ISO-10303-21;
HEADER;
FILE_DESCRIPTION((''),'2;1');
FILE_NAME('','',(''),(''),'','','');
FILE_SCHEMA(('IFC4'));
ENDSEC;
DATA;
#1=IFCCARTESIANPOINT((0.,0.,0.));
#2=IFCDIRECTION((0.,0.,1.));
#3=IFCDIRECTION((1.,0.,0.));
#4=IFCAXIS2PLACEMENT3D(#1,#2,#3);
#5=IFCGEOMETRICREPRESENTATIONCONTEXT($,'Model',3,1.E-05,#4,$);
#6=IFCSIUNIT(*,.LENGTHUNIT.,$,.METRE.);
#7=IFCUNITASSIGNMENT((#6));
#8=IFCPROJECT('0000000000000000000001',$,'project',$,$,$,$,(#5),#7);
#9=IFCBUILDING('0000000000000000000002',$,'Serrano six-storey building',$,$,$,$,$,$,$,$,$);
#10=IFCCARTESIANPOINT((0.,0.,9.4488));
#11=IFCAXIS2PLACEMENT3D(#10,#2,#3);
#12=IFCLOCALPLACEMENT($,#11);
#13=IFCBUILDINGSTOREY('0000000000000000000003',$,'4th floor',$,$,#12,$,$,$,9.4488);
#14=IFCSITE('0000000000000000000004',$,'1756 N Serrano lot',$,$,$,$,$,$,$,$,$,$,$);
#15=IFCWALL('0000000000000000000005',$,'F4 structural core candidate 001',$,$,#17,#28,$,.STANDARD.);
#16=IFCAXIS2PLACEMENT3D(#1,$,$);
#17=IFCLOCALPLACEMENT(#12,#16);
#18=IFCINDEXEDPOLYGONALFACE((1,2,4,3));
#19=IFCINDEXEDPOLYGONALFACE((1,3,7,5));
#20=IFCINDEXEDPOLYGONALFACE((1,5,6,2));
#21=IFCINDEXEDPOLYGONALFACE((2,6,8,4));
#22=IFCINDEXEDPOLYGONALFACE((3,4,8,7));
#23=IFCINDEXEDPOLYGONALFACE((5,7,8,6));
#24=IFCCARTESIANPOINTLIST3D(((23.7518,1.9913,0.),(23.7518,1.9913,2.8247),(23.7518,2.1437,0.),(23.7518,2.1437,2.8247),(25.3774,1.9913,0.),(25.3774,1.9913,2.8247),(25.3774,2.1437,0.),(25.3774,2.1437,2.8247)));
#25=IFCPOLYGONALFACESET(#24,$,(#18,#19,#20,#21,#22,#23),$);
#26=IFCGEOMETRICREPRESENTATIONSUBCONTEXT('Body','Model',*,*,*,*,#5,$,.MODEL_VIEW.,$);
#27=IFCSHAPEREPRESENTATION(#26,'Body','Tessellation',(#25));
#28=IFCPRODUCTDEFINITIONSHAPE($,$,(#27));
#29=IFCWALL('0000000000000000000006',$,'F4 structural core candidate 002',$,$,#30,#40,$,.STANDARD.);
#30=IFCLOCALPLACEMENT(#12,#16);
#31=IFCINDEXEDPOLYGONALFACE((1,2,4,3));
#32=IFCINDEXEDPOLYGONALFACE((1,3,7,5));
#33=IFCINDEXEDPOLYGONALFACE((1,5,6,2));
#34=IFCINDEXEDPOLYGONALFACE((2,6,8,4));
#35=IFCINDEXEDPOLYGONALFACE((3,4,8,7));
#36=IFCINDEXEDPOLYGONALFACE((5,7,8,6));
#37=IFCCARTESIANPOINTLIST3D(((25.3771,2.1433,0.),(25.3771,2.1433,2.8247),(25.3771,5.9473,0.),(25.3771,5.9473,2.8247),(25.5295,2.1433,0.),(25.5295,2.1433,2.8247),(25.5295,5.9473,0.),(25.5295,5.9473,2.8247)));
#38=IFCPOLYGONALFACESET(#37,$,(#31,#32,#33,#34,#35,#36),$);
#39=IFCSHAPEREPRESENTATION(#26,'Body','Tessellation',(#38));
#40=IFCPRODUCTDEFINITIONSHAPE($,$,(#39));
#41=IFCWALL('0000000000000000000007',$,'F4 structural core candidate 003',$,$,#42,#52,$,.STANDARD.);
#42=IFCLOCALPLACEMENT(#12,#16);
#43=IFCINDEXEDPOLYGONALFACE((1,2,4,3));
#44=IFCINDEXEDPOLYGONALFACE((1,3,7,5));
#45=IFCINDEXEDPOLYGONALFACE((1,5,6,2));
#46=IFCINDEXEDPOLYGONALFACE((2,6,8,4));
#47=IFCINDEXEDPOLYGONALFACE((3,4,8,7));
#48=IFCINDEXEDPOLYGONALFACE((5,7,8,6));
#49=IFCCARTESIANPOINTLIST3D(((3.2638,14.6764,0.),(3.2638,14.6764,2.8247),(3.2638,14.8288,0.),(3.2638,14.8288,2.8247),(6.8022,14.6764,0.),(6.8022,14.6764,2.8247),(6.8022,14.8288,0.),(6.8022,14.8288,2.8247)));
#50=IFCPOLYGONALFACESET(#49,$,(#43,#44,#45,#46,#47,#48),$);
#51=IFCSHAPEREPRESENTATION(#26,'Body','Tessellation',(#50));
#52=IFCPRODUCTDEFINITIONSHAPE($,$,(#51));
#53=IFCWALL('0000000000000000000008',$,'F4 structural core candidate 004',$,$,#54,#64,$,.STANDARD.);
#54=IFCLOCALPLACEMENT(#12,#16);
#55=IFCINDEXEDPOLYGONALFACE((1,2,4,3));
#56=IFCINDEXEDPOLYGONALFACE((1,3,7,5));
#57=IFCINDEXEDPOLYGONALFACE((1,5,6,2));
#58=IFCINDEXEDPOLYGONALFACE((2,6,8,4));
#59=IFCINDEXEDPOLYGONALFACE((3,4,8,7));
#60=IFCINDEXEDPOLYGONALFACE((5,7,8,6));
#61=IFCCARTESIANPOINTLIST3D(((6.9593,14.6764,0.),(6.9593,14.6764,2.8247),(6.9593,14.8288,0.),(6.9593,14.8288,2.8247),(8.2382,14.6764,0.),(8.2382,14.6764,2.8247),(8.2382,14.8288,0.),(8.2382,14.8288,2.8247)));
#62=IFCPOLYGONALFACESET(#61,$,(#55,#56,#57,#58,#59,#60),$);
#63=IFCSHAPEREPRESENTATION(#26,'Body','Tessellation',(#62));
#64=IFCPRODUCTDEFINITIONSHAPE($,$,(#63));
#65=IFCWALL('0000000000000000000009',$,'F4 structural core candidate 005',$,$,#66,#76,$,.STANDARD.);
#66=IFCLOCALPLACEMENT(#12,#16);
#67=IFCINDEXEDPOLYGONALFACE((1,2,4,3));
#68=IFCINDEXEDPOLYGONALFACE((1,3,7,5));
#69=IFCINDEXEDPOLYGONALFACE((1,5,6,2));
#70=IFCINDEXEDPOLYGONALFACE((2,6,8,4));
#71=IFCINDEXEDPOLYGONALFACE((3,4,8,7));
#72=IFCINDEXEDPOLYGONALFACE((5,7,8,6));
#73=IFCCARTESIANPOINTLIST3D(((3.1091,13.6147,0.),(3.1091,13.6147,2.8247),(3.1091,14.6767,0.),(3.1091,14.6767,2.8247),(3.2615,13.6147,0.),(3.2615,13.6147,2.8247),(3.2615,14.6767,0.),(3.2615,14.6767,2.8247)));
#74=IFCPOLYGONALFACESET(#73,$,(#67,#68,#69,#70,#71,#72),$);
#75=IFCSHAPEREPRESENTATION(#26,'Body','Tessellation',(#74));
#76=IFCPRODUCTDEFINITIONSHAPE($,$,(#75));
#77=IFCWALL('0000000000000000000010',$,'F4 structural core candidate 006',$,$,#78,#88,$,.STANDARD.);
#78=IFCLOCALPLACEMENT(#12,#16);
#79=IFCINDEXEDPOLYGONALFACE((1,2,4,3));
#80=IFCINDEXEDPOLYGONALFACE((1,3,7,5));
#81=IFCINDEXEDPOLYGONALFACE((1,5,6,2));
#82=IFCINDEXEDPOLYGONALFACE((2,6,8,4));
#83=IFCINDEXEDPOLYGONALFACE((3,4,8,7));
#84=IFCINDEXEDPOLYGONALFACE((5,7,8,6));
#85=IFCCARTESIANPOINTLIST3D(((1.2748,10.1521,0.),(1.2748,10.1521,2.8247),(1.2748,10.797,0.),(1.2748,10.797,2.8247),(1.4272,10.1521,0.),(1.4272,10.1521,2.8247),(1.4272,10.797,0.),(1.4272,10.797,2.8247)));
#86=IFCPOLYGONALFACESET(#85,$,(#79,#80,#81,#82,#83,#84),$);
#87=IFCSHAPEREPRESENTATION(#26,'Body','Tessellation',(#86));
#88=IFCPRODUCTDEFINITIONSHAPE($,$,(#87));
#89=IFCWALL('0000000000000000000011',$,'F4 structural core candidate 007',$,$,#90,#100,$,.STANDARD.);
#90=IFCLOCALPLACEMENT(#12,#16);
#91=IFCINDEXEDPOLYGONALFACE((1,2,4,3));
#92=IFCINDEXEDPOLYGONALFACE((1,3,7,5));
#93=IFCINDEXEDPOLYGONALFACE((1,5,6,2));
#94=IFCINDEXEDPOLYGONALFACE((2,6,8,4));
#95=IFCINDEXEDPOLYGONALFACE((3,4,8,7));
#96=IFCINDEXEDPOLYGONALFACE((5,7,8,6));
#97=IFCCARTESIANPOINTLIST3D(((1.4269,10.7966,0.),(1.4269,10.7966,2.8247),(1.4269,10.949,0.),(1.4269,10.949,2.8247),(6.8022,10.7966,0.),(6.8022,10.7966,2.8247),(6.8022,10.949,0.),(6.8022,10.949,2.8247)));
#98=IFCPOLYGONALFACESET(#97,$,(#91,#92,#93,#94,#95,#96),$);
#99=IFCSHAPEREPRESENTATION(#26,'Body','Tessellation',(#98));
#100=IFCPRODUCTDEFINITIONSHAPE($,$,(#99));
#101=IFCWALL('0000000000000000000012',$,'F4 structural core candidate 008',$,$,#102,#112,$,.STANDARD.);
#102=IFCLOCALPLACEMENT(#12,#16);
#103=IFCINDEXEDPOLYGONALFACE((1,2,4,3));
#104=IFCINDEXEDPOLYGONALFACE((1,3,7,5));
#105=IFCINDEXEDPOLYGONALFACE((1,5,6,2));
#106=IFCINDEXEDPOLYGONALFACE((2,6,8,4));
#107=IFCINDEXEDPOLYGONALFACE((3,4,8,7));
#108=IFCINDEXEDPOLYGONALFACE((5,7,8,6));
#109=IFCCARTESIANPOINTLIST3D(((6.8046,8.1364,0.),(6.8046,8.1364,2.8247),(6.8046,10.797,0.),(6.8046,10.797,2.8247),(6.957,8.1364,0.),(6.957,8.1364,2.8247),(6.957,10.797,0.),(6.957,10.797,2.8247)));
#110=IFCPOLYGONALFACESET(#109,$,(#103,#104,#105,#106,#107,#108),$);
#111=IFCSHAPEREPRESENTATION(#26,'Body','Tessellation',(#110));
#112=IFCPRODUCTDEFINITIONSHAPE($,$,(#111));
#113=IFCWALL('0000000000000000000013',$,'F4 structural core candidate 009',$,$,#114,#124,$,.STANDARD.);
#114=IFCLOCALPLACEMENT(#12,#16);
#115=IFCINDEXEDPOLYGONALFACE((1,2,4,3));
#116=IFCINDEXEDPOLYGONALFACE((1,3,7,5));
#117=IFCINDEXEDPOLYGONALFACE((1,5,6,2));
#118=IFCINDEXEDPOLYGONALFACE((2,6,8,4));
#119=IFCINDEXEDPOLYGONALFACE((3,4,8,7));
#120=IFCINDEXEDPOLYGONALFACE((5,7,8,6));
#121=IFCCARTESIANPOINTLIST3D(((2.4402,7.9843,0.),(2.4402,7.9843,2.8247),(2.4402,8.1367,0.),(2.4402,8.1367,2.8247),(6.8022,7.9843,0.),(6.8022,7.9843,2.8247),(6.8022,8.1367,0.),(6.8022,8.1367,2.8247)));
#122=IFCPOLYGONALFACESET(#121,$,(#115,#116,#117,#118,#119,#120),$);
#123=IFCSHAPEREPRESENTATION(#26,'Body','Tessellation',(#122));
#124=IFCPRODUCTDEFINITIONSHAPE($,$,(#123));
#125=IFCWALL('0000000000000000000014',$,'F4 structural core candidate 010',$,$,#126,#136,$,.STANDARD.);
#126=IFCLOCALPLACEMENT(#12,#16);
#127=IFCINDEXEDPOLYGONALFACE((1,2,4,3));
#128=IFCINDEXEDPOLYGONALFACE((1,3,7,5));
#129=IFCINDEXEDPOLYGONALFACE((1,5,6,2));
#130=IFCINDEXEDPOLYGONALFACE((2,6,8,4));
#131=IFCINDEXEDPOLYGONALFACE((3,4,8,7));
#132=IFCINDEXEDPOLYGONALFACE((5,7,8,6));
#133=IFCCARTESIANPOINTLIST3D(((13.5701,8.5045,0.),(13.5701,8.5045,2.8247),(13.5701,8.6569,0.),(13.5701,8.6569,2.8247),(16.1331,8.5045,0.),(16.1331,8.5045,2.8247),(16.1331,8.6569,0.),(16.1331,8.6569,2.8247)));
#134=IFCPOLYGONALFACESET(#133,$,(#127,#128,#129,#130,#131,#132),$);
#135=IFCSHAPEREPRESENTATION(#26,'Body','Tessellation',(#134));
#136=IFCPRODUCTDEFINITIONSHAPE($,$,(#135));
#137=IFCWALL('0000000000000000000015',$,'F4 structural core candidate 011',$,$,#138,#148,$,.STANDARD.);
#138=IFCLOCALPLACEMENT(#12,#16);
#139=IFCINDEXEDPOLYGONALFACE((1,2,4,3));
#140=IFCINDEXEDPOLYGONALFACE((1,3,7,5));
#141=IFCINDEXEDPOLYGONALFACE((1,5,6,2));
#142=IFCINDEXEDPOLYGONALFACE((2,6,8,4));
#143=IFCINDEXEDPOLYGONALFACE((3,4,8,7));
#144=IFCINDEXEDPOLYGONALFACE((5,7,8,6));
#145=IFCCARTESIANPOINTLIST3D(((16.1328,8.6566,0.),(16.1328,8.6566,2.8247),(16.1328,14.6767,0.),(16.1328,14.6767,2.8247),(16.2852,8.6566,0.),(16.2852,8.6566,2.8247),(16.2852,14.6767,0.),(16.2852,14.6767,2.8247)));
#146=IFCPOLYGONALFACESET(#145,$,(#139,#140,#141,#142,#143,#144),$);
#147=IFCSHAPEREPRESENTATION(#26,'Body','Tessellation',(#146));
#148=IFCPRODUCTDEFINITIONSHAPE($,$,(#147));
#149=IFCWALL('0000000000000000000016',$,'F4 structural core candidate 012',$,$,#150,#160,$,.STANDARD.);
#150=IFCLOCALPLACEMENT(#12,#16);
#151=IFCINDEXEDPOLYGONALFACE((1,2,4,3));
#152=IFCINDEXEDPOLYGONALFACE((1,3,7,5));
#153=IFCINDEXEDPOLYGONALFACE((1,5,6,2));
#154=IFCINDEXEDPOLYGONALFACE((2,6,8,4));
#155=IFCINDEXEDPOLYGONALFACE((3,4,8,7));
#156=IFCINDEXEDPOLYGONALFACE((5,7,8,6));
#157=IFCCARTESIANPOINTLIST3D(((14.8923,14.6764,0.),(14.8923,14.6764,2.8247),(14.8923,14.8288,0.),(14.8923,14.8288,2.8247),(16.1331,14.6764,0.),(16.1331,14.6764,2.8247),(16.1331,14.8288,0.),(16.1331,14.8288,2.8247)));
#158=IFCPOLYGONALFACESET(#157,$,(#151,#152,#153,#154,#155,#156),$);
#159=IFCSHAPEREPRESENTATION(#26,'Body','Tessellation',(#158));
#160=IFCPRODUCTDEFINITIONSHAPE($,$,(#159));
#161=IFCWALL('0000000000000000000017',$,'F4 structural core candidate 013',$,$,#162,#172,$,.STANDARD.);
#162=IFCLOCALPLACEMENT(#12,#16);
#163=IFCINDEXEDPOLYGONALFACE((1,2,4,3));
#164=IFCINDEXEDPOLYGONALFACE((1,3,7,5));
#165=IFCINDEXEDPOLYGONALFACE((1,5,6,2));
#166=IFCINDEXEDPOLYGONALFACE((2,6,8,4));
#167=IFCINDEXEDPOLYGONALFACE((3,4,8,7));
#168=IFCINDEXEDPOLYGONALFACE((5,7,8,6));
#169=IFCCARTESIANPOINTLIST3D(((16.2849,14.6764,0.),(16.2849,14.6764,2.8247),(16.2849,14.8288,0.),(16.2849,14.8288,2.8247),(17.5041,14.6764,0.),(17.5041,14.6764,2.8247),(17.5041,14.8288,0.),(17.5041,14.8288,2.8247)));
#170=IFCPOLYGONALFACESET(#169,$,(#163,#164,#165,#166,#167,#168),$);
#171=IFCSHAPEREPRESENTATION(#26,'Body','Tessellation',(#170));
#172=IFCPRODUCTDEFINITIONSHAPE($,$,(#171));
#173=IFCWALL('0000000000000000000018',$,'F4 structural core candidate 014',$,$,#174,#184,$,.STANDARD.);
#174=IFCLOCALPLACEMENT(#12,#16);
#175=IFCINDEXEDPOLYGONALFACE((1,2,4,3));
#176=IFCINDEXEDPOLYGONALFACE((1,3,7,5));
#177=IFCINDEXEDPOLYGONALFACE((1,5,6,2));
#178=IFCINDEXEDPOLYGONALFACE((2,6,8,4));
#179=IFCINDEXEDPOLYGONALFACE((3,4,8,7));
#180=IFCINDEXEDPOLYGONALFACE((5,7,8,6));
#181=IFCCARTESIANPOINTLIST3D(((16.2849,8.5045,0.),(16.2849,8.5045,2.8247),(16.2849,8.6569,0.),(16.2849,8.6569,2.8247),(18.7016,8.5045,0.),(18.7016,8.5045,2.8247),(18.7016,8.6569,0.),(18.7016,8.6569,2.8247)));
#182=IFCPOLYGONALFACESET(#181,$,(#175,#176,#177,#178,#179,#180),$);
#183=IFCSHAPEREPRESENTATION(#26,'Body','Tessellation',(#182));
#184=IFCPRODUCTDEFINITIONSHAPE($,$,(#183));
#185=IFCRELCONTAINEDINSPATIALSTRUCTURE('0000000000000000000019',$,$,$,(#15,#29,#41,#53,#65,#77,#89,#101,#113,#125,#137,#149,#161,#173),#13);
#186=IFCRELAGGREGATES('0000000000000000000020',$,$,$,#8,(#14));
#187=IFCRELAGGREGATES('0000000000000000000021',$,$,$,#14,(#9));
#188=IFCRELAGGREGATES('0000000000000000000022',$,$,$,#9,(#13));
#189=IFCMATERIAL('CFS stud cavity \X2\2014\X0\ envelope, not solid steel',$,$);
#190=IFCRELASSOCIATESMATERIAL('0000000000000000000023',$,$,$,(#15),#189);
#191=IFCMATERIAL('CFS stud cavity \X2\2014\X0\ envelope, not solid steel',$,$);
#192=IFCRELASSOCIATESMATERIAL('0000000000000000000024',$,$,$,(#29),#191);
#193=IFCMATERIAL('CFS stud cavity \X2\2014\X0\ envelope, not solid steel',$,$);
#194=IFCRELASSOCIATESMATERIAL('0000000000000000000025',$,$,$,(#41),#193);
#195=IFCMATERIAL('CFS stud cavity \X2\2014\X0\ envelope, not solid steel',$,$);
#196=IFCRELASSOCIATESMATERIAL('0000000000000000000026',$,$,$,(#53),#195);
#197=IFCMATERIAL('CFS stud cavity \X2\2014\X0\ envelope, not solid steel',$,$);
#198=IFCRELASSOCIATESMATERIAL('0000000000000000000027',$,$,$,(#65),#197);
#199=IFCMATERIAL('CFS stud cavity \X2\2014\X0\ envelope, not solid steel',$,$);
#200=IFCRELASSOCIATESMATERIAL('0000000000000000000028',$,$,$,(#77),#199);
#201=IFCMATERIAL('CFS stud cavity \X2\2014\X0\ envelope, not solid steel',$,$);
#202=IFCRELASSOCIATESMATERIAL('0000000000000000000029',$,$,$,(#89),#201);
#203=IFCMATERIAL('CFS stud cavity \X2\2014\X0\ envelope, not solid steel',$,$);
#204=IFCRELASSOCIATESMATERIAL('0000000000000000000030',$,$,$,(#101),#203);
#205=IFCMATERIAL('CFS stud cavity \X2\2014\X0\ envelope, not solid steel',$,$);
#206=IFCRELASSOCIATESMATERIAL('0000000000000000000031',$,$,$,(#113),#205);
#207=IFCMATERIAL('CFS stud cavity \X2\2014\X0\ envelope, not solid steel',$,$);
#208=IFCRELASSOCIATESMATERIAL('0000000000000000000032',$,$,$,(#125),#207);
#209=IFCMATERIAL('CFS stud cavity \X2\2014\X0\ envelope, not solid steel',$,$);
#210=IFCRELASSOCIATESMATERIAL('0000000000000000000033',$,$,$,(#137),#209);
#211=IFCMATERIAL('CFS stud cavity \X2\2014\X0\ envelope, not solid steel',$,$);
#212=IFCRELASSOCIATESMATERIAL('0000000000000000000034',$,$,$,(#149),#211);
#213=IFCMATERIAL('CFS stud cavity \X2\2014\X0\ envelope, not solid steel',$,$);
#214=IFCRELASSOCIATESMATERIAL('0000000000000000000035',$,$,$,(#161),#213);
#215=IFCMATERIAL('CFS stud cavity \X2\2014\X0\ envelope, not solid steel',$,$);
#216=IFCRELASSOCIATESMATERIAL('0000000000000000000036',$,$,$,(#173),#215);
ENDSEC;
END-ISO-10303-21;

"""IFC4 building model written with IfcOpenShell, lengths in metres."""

from ifc_helpers import new_model, si_unit, frame, origin_with_axes, place, context, subcontext, project, spatial, polyline, outline, extrude, material, element, save


model = new_model("IFC4")

# Units and contexts
model_context = context("Model", 3, precision=1e-05, world=origin_with_axes())
body_context = subcontext(model_context, "Body", "Model", "MODEL_VIEW")
ifc_project = project(units=[si_unit("LENGTHUNIT", "METRE")], contexts=[model_context])

# Site, building, storey
site = spatial("IfcSite", under=ifc_project, Name="1756 N Serrano lot")
building = spatial("IfcBuilding", under=site, Name="Serrano six-storey building")
storey_placement = place(None, frame((0.0, 0.0, 9.4488), z_axis=(0.0, 0.0, 1.0), x_axis=(1.0, 0.0, 0.0)))
storey = spatial("IfcBuildingStorey", under=building, at=storey_placement, Name="4th floor", Elevation=9.4488)

# Walls
ifc_material_1 = material(Name="CFS stud cavity — envelope, not solid steel")
wall_1_placement = place(storey_placement, frame((0.0, 0.0, -9.4488), z_axis=(0.0, 0.0, 1.0), x_axis=(1.0, 0.0, 0.0)))
element("IfcWall", 1, at=wall_1_placement, inside=storey, material=ifc_material_1, Name="F4 structural core candidate 001", PredefinedType="STANDARD", context=body_context, shape_type="SweptSolid", body=[
    extrude(outline(polyline([(25.3774, 2.1437), (25.3774, 1.9913), (23.7518, 1.9913), (23.7518, 2.1437), (25.3774, 2.1437)])), frame((0.0, 0.0, 9.4488)), (0.0, 0.0, 1.0), 2.8247),
])
ifc_material_2 = material(Name="CFS stud cavity — envelope, not solid steel")
wall_2_placement = place(storey_placement, frame((0.0, 0.0, -9.4488), z_axis=(0.0, 0.0, 1.0), x_axis=(1.0, 0.0, 0.0)))
element("IfcWall", 2, at=wall_2_placement, inside=storey, material=ifc_material_2, Name="F4 structural core candidate 002", PredefinedType="STANDARD", context=body_context, shape_type="SweptSolid", body=[
    extrude(outline(polyline([(25.5295, 2.1433), (25.3771, 2.1433), (25.3771, 5.9473), (25.5295, 5.9473), (25.5295, 2.1433)])), frame((0.0, 0.0, 9.4488)), (0.0, 0.0, 1.0), 2.8247),
])
ifc_material_3 = material(Name="CFS stud cavity — envelope, not solid steel")
wall_3_placement = place(storey_placement, frame((0.0, 0.0, -9.4488), z_axis=(0.0, 0.0, 1.0), x_axis=(1.0, 0.0, 0.0)))
element("IfcWall", 3, at=wall_3_placement, inside=storey, material=ifc_material_3, Name="F4 structural core candidate 003", PredefinedType="STANDARD", context=body_context, shape_type="SweptSolid", body=[
    extrude(outline(polyline([(6.8022, 14.8288), (6.8022, 14.6764), (3.2638, 14.6764), (3.2638, 14.8288), (6.8022, 14.8288)])), frame((0.0, 0.0, 9.4488)), (0.0, 0.0, 1.0), 2.8247),
])
ifc_material_4 = material(Name="CFS stud cavity — envelope, not solid steel")
wall_4_placement = place(storey_placement, frame((0.0, 0.0, -9.4488), z_axis=(0.0, 0.0, 1.0), x_axis=(1.0, 0.0, 0.0)))
element("IfcWall", 4, at=wall_4_placement, inside=storey, material=ifc_material_4, Name="F4 structural core candidate 004", PredefinedType="STANDARD", context=body_context, shape_type="SweptSolid", body=[
    extrude(outline(polyline([(8.2382, 14.8288), (8.2382, 14.6764), (6.9593, 14.6764), (6.9593, 14.8288), (8.2382, 14.8288)])), frame((0.0, 0.0, 9.4488)), (0.0, 0.0, 1.0), 2.8247),
])
ifc_material_5 = material(Name="CFS stud cavity — envelope, not solid steel")
wall_5_placement = place(storey_placement, frame((0.0, 0.0, -9.4488), z_axis=(0.0, 0.0, 1.0), x_axis=(1.0, 0.0, 0.0)))
element("IfcWall", 5, at=wall_5_placement, inside=storey, material=ifc_material_5, Name="F4 structural core candidate 005", PredefinedType="STANDARD", context=body_context, shape_type="SweptSolid", body=[
    extrude(outline(polyline([(3.2615, 13.6147), (3.1091, 13.6147), (3.1091, 14.6767), (3.2615, 14.6767), (3.2615, 13.6147)])), frame((0.0, 0.0, 9.4488)), (0.0, 0.0, 1.0), 2.8247),
])
ifc_material_6 = material(Name="CFS stud cavity — envelope, not solid steel")
wall_6_placement = place(storey_placement, frame((0.0, 0.0, -9.4488), z_axis=(0.0, 0.0, 1.0), x_axis=(1.0, 0.0, 0.0)))
element("IfcWall", 6, at=wall_6_placement, inside=storey, material=ifc_material_6, Name="F4 structural core candidate 006", PredefinedType="STANDARD", context=body_context, shape_type="SweptSolid", body=[
    extrude(outline(polyline([(1.4272, 10.1521), (1.2748, 10.1521), (1.2748, 10.797), (1.4272, 10.797), (1.4272, 10.1521)])), frame((0.0, 0.0, 9.4488)), (0.0, 0.0, 1.0), 2.8247),
])
ifc_material_7 = material(Name="CFS stud cavity — envelope, not solid steel")
wall_7_placement = place(storey_placement, frame((0.0, 0.0, -9.4488), z_axis=(0.0, 0.0, 1.0), x_axis=(1.0, 0.0, 0.0)))
element("IfcWall", 7, at=wall_7_placement, inside=storey, material=ifc_material_7, Name="F4 structural core candidate 007", PredefinedType="STANDARD", context=body_context, shape_type="SweptSolid", body=[
    extrude(outline(polyline([(6.8022, 10.949), (6.8022, 10.7966), (1.4269, 10.7966), (1.4269, 10.949), (6.8022, 10.949)])), frame((0.0, 0.0, 9.4488)), (0.0, 0.0, 1.0), 2.8247),
])
ifc_material_8 = material(Name="CFS stud cavity — envelope, not solid steel")
wall_8_placement = place(storey_placement, frame((0.0, 0.0, -9.4488), z_axis=(0.0, 0.0, 1.0), x_axis=(1.0, 0.0, 0.0)))
element("IfcWall", 8, at=wall_8_placement, inside=storey, material=ifc_material_8, Name="F4 structural core candidate 008", PredefinedType="STANDARD", context=body_context, shape_type="SweptSolid", body=[
    extrude(outline(polyline([(6.957, 8.1364), (6.8046, 8.1364), (6.8046, 10.797), (6.957, 10.797), (6.957, 8.1364)])), frame((0.0, 0.0, 9.4488)), (0.0, 0.0, 1.0), 2.8247),
])
ifc_material_9 = material(Name="CFS stud cavity — envelope, not solid steel")
wall_9_placement = place(storey_placement, frame((0.0, 0.0, -9.4488), z_axis=(0.0, 0.0, 1.0), x_axis=(1.0, 0.0, 0.0)))
element("IfcWall", 9, at=wall_9_placement, inside=storey, material=ifc_material_9, Name="F4 structural core candidate 009", PredefinedType="STANDARD", context=body_context, shape_type="SweptSolid", body=[
    extrude(outline(polyline([(6.8022, 8.1367), (6.8022, 7.9843), (2.4402, 7.9843), (2.4402, 8.1367), (6.8022, 8.1367)])), frame((0.0, 0.0, 9.4488)), (0.0, 0.0, 1.0), 2.8247),
])
ifc_material_10 = material(Name="CFS stud cavity — envelope, not solid steel")
wall_10_placement = place(storey_placement, frame((0.0, 0.0, -9.4488), z_axis=(0.0, 0.0, 1.0), x_axis=(1.0, 0.0, 0.0)))
element("IfcWall", 10, at=wall_10_placement, inside=storey, material=ifc_material_10, Name="F4 structural core candidate 010", PredefinedType="STANDARD", context=body_context, shape_type="SweptSolid", body=[
    extrude(outline(polyline([(16.1331, 8.6569), (16.1331, 8.5045), (13.5701, 8.5045), (13.5701, 8.6569), (16.1331, 8.6569)])), frame((0.0, 0.0, 9.4488)), (0.0, 0.0, 1.0), 2.8247),
])
ifc_material_11 = material(Name="CFS stud cavity — envelope, not solid steel")
wall_11_placement = place(storey_placement, frame((0.0, 0.0, -9.4488), z_axis=(0.0, 0.0, 1.0), x_axis=(1.0, 0.0, 0.0)))
element("IfcWall", 11, at=wall_11_placement, inside=storey, material=ifc_material_11, Name="F4 structural core candidate 011", PredefinedType="STANDARD", context=body_context, shape_type="SweptSolid", body=[
    extrude(outline(polyline([(16.2852, 8.6566), (16.1328, 8.6566), (16.1328, 14.6767), (16.2852, 14.6767), (16.2852, 8.6566)])), frame((0.0, 0.0, 9.4488)), (0.0, 0.0, 1.0), 2.8247),
])
ifc_material_12 = material(Name="CFS stud cavity — envelope, not solid steel")
wall_12_placement = place(storey_placement, frame((0.0, 0.0, -9.4488), z_axis=(0.0, 0.0, 1.0), x_axis=(1.0, 0.0, 0.0)))
element("IfcWall", 12, at=wall_12_placement, inside=storey, material=ifc_material_12, Name="F4 structural core candidate 012", PredefinedType="STANDARD", context=body_context, shape_type="SweptSolid", body=[
    extrude(outline(polyline([(16.1331, 14.8288), (16.1331, 14.6764), (14.8923, 14.6764), (14.8923, 14.8288), (16.1331, 14.8288)])), frame((0.0, 0.0, 9.4488)), (0.0, 0.0, 1.0), 2.8247),
])
ifc_material_13 = material(Name="CFS stud cavity — envelope, not solid steel")
wall_13_placement = place(storey_placement, frame((0.0, 0.0, -9.4488), z_axis=(0.0, 0.0, 1.0), x_axis=(1.0, 0.0, 0.0)))
element("IfcWall", 13, at=wall_13_placement, inside=storey, material=ifc_material_13, Name="F4 structural core candidate 013", PredefinedType="STANDARD", context=body_context, shape_type="SweptSolid", body=[
    extrude(outline(polyline([(17.5041, 14.8288), (17.5041, 14.6764), (16.2849, 14.6764), (16.2849, 14.8288), (17.5041, 14.8288)])), frame((0.0, 0.0, 9.4488)), (0.0, 0.0, 1.0), 2.8247),
])
ifc_material_14 = material(Name="CFS stud cavity — envelope, not solid steel")
wall_14_placement = place(storey_placement, frame((0.0, 0.0, -9.4488), z_axis=(0.0, 0.0, 1.0), x_axis=(1.0, 0.0, 0.0)))
element("IfcWall", 14, at=wall_14_placement, inside=storey, material=ifc_material_14, Name="F4 structural core candidate 014", PredefinedType="STANDARD", context=body_context, shape_type="SweptSolid", body=[
    extrude(outline(polyline([(18.7016, 8.6569), (18.7016, 8.5045), (16.2849, 8.5045), (16.2849, 8.6569), (18.7016, 8.6569)])), frame((0.0, 0.0, 9.4488)), (0.0, 0.0, 1.0), 2.8247),
])

save(model, "model.ifc")
